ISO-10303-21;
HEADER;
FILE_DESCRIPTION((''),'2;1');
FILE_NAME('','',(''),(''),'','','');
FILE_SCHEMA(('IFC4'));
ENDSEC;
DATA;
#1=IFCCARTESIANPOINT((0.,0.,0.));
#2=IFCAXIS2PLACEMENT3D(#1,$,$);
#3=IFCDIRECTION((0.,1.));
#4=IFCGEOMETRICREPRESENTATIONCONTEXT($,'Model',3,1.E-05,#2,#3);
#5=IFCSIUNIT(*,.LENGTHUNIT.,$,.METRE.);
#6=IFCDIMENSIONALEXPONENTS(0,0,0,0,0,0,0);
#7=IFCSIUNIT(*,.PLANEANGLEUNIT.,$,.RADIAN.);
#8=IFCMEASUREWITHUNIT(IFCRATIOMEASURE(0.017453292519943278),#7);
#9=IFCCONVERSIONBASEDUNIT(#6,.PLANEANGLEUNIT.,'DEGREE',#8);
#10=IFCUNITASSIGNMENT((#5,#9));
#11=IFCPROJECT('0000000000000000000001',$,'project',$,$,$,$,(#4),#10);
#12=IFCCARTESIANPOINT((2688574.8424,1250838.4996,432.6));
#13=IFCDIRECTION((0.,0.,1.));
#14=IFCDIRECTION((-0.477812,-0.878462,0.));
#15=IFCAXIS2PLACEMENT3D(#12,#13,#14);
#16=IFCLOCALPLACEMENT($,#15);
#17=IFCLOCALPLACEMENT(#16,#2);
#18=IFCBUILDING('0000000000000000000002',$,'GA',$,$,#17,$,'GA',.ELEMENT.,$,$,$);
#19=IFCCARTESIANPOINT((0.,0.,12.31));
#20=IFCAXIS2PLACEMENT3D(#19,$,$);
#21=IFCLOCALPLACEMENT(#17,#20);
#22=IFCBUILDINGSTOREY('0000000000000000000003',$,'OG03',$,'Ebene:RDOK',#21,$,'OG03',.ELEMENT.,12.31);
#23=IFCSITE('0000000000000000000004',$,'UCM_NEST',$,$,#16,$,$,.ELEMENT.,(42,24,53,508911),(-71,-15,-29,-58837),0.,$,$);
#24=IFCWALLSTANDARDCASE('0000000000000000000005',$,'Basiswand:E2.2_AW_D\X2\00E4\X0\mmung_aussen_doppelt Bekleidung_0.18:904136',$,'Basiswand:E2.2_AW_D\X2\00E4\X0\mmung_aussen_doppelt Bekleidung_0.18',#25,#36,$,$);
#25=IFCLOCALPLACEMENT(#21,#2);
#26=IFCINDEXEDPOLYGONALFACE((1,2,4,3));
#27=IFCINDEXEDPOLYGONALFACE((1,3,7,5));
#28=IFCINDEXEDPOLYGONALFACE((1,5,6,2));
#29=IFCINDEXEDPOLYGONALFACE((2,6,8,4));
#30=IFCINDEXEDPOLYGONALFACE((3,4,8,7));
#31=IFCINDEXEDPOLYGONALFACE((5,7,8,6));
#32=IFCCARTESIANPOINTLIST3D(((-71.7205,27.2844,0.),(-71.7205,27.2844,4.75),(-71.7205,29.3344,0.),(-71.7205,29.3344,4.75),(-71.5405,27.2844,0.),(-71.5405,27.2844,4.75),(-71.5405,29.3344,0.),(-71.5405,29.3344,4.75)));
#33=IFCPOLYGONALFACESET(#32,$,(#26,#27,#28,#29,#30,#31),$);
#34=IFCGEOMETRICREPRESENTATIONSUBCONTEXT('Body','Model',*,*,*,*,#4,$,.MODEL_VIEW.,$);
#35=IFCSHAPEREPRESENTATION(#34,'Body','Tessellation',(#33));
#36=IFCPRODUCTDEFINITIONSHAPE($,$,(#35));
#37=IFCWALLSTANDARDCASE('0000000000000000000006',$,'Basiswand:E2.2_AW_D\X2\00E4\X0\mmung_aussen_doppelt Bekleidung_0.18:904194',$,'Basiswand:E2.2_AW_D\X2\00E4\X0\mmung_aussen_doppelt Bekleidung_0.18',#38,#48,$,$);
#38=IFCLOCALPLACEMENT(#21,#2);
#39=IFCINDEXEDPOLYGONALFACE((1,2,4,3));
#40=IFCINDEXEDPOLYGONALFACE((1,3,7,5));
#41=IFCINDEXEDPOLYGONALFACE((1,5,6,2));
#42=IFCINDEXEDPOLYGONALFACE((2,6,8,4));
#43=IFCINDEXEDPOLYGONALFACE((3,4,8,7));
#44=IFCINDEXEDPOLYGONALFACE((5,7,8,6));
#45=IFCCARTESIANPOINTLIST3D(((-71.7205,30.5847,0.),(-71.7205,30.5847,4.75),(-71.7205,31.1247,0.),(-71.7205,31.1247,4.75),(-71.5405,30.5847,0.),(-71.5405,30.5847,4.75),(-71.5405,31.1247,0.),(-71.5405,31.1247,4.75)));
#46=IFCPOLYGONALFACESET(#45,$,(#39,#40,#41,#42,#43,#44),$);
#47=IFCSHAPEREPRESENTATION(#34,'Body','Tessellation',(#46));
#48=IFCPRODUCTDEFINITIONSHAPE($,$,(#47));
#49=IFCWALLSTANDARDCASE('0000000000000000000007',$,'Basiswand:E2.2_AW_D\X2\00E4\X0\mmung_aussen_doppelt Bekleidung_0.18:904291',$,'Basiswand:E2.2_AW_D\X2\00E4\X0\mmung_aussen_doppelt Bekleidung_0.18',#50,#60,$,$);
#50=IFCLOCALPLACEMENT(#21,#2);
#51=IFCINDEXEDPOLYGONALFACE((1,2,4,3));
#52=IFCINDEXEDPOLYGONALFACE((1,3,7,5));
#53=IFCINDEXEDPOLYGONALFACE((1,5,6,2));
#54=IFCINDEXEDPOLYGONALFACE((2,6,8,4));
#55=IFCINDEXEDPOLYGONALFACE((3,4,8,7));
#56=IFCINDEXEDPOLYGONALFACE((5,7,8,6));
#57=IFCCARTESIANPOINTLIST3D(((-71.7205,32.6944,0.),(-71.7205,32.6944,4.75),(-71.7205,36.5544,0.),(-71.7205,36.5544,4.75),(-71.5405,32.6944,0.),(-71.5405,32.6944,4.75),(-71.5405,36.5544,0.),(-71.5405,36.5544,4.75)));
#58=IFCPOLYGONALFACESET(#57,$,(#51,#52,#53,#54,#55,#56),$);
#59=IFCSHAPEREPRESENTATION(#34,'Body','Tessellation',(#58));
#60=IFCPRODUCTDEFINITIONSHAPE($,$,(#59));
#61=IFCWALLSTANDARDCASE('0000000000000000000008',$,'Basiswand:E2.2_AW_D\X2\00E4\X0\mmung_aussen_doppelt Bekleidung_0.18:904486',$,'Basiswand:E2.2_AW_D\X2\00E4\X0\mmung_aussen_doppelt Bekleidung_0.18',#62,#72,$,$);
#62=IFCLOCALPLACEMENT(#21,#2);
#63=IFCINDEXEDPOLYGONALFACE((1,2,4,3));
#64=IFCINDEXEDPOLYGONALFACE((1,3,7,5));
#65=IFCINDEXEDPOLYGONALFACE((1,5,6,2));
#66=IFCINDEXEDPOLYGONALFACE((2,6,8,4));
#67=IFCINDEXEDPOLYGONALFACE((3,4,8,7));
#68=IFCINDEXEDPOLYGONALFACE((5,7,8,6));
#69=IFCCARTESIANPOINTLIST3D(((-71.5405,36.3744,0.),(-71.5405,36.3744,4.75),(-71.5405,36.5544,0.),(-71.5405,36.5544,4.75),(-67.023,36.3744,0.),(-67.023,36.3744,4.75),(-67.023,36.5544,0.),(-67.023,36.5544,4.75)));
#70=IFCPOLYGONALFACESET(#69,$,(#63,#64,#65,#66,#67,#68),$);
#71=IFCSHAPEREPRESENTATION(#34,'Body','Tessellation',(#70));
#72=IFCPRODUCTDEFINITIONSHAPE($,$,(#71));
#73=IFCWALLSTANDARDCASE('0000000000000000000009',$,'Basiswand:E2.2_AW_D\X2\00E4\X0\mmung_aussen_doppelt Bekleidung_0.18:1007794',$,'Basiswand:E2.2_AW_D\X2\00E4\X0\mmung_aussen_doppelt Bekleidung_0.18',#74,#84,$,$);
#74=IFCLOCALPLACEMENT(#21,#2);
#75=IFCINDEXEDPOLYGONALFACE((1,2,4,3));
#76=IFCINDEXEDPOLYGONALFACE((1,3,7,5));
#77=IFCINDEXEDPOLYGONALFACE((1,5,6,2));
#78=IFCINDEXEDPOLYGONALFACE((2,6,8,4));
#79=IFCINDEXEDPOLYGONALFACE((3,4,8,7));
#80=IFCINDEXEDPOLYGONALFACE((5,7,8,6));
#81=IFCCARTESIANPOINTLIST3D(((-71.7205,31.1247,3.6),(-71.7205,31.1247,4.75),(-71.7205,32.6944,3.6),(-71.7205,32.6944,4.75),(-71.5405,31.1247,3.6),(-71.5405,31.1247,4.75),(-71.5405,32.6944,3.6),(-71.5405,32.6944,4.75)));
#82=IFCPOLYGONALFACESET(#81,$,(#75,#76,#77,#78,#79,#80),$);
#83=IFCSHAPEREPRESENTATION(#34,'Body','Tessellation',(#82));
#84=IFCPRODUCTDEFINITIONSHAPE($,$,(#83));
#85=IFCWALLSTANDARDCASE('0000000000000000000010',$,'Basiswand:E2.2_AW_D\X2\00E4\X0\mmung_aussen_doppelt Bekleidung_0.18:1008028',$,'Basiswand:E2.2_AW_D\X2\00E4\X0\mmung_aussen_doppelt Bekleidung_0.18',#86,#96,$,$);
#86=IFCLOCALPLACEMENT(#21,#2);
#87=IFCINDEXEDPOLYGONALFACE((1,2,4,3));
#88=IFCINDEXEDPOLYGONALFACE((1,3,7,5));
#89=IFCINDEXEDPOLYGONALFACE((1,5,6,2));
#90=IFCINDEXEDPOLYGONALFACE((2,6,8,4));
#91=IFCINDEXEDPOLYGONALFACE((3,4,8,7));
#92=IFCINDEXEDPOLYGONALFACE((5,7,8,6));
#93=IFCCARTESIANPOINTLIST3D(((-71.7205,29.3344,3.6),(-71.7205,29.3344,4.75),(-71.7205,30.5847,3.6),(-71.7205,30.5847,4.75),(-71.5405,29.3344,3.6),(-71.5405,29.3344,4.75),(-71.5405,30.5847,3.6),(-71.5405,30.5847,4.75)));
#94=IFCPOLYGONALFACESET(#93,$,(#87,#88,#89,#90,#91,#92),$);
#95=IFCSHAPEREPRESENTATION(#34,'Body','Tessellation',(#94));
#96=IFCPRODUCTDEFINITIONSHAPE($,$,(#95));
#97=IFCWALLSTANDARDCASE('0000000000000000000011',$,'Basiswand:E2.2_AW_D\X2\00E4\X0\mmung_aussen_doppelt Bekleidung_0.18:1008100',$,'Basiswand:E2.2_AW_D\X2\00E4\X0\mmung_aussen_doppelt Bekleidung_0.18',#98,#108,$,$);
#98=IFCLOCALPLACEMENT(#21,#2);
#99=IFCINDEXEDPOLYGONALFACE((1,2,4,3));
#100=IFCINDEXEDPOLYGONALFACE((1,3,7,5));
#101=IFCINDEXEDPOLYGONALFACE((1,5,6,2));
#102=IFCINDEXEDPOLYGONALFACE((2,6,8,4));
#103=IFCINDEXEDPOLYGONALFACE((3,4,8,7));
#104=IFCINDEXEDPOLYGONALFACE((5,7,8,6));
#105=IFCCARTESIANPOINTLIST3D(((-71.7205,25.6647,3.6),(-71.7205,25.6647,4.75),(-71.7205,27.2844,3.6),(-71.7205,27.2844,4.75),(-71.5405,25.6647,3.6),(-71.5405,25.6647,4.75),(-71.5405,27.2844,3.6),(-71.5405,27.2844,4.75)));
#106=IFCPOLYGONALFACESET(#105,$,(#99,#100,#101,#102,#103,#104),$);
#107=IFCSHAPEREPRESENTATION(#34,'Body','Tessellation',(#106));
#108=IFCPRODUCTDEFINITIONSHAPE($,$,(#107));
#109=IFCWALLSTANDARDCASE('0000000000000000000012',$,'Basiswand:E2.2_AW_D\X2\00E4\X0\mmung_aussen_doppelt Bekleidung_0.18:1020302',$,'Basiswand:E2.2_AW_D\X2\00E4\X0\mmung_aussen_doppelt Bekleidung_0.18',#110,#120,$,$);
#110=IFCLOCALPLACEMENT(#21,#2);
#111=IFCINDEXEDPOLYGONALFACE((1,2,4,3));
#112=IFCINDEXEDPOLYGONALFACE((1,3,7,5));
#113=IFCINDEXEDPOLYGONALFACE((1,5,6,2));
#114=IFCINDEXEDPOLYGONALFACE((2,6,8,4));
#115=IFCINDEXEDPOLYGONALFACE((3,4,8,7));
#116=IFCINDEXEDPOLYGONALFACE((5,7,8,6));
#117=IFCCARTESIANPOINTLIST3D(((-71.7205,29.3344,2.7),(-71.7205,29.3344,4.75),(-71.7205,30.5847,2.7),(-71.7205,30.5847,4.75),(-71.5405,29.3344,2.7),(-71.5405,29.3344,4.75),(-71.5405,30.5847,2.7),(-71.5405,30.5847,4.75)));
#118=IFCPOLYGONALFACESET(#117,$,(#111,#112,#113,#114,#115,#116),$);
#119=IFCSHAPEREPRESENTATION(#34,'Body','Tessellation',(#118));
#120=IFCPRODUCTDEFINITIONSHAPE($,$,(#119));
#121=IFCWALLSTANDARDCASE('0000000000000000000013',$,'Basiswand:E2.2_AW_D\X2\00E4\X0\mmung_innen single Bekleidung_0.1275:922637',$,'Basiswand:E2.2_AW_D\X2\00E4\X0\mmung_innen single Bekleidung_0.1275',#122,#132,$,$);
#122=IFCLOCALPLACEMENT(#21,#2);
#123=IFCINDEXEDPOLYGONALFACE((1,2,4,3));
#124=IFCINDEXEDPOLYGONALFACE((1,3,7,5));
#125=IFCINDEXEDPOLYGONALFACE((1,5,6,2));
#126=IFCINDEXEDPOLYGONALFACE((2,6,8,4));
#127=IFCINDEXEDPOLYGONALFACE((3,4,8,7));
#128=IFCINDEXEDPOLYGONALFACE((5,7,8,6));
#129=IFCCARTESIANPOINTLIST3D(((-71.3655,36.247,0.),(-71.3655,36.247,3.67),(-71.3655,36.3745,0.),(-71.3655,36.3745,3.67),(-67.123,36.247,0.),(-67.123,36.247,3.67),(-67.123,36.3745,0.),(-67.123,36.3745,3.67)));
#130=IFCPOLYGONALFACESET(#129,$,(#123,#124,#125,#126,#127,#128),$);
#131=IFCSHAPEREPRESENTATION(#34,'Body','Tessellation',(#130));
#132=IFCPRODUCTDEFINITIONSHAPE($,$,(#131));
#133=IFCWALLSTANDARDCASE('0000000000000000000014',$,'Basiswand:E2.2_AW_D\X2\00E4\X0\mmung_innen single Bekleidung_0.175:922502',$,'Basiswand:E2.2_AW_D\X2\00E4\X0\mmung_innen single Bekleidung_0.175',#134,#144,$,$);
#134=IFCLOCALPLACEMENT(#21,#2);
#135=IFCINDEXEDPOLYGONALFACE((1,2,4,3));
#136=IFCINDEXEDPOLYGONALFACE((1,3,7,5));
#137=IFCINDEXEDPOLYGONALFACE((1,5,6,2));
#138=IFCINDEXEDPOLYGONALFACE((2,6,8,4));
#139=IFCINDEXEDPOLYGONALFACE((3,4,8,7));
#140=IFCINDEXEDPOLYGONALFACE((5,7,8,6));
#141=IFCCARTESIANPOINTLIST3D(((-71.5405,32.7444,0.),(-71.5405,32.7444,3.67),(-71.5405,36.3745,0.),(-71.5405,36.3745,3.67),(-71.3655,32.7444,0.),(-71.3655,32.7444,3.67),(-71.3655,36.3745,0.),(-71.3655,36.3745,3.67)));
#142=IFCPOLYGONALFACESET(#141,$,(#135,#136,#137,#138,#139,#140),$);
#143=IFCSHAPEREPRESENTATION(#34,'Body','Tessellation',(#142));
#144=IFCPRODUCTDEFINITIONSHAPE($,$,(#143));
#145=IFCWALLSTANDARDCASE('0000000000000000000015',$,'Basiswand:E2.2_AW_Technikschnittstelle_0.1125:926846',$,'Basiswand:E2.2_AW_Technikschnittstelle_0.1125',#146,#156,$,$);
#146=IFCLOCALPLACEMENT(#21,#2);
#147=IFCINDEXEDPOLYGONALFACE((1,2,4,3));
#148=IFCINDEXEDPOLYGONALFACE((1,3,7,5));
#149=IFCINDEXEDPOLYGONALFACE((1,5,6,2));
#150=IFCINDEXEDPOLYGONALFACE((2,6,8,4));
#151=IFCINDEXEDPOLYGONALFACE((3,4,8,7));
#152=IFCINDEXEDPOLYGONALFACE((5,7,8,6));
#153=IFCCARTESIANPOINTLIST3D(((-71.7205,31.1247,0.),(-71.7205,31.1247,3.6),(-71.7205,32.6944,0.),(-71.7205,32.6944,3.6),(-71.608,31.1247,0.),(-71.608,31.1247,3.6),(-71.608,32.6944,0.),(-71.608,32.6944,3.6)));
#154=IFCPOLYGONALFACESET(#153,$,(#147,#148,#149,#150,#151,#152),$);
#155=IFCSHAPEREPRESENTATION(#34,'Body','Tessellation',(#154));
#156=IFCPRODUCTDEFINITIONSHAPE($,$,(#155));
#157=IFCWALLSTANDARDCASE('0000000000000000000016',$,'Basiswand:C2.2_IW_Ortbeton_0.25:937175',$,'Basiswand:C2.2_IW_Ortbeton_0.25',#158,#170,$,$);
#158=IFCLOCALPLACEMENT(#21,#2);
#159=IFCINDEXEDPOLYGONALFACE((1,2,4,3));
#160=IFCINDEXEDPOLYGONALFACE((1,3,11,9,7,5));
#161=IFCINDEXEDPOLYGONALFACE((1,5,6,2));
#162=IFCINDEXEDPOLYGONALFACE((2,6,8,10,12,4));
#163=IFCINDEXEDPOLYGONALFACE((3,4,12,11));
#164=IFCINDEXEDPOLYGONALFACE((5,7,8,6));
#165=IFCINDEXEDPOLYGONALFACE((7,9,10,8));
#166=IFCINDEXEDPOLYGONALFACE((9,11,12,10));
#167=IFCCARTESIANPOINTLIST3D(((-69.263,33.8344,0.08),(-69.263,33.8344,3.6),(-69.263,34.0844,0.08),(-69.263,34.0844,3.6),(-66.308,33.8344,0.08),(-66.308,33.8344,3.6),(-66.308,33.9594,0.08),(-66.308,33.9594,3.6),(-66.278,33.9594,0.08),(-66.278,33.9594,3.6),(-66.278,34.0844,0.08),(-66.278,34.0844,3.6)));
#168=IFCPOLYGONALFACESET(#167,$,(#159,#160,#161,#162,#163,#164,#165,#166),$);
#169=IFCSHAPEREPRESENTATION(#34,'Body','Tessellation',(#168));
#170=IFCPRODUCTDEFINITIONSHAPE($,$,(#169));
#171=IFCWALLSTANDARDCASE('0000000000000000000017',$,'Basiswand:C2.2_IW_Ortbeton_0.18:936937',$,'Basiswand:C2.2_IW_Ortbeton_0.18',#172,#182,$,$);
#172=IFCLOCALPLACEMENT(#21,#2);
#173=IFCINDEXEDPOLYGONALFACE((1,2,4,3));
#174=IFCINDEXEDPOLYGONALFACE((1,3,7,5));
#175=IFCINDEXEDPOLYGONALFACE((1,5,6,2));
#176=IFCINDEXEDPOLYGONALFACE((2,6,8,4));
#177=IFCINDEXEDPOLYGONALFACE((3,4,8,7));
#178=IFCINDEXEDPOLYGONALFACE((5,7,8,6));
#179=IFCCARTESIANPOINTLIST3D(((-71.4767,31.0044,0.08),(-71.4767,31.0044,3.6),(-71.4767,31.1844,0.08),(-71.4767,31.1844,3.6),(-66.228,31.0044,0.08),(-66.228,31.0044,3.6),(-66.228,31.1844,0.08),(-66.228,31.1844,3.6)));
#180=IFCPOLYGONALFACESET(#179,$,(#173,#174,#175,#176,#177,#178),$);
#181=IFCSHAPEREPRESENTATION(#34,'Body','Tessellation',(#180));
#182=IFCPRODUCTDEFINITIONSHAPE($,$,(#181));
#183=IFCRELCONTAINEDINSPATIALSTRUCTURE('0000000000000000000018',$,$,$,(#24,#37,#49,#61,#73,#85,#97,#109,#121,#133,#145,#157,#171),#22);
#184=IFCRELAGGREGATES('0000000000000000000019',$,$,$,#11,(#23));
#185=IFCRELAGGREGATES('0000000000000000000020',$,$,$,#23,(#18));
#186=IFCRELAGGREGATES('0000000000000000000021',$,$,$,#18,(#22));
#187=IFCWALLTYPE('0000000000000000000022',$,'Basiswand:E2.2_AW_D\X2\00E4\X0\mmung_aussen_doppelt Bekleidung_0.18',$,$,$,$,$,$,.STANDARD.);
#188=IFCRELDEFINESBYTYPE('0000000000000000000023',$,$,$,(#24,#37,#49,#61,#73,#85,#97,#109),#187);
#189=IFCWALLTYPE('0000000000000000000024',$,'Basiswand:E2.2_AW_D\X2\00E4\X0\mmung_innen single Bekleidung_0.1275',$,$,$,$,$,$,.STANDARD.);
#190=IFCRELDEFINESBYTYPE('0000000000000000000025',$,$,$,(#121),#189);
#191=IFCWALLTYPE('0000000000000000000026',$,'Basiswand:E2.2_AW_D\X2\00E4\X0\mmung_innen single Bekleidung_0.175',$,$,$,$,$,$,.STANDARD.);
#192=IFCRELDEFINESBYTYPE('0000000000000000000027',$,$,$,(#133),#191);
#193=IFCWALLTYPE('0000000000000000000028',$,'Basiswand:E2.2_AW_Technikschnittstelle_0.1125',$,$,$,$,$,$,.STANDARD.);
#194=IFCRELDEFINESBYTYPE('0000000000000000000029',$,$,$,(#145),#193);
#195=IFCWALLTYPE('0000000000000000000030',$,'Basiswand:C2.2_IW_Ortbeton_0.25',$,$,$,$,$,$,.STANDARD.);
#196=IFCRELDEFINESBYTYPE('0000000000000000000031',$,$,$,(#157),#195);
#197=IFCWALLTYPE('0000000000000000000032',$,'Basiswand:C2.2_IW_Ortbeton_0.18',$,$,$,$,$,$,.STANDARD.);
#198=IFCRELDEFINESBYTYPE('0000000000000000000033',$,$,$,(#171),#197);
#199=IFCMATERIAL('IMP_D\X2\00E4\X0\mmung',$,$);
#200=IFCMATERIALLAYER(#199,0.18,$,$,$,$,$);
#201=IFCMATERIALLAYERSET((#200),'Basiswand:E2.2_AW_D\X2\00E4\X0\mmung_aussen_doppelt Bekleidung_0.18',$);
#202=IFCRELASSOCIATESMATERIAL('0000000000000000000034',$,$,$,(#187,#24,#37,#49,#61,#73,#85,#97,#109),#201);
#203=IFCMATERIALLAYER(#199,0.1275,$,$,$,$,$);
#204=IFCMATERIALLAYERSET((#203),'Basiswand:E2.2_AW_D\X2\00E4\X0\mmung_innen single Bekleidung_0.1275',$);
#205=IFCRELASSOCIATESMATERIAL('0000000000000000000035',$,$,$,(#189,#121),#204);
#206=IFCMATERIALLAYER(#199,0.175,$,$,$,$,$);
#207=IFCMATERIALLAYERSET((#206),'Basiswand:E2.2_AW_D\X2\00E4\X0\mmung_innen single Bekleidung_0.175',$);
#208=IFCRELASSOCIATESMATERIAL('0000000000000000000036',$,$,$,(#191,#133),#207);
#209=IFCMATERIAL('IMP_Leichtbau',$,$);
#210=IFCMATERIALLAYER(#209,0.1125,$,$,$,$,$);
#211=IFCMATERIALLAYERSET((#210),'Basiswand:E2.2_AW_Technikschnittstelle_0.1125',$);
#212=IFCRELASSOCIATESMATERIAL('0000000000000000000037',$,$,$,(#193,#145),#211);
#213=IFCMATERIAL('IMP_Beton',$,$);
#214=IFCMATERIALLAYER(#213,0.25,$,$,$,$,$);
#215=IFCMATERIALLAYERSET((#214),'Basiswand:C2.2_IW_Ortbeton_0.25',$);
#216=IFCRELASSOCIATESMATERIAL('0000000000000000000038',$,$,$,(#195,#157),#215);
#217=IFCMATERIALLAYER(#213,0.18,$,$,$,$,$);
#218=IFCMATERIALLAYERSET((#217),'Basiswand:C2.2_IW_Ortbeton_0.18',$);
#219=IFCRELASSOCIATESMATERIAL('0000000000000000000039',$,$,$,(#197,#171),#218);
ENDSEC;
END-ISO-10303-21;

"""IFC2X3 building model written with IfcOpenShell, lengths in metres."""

from ifc_helpers import new_model, entity, si_unit, converted_unit, direction, frame, frame_2d, origin, place, context, subcontext, project, spatial, polyline, rectangle, outline, extrude, clip, bounded_halfspace, material, layer, layer_set, layer_usage, type_object, element, save


model = new_model("IFC2X3")

# Units and contexts
model_context = context("Model", 3, precision=1e-05, world=origin(), true_north=direction((0.0, 1.0)))
body_context = subcontext(model_context, "Body", "Model", "MODEL_VIEW")
ifc_project = project(units=[si_unit("LENGTHUNIT", "METRE"), converted_unit("PLANEANGLEUNIT", "DEGREE", entity("IfcRatioMeasure", 0.017453292519943278), si_unit("PLANEANGLEUNIT", "RADIAN"), dimensions=[0, 0, 0, 0, 0, 0, 0])], contexts=[model_context])

# Site, building, storey
site_placement = place(None, frame((2688574.8424, 1250838.4996, 432.6), z_axis=(0.0, 0.0, 1.0), x_axis=(-0.477812, -0.878462, 0.0)))
site = spatial("IfcSite", under=ifc_project, at=site_placement, Name="UCM_NEST", CompositionType="ELEMENT", RefLatitude=(42, 24, 53, 508911), RefLongitude=(-71, -15, -29, -58837), RefElevation=0.0)
building_placement = place(site_placement, origin())
building = spatial("IfcBuilding", under=site, at=building_placement, Name="GA", LongName="GA", CompositionType="ELEMENT")
storey_placement = place(building_placement, frame((0.0, 0.0, 12.31)))
storey = spatial("IfcBuildingStorey", under=building, at=storey_placement, Name="OG03", ObjectType="Ebene:RDOK", LongName="OG03", CompositionType="ELEMENT", Elevation=12.31)

# Walls
ifc_material_1 = material(Name="IMP_Dämmung")
ifc_layer_1 = layer(ifc_material_1, 0.18)
ifc_layer_set_1 = layer_set([ifc_layer_1], Name="Basiswand:E2.2_AW_Dämmung_aussen_doppelt Bekleidung_0.18")
ifc_layer_usage_1 = layer_usage(ifc_layer_set_1, "AXIS2", "NEGATIVE", 0.09)
wall_type_1 = type_object("IfcWallType", Name="Basiswand:E2.2_AW_Dämmung_aussen_doppelt Bekleidung_0.18", PredefinedType="STANDARD", material=ifc_layer_set_1)
wall_1_placement = place(storey_placement, frame((-71.6305, 27.2844, 0.0), z_axis=(0.0, 0.0, 1.0), x_axis=(0.0, 1.0, 0.0)))
element("IfcWallStandardCase", 1, at=wall_1_placement, inside=storey, type_object=wall_type_1, material=ifc_layer_usage_1, Name="Basiswand:E2.2_AW_Dämmung_aussen_doppelt Bekleidung_0.18:904136", ObjectType="Basiswand:E2.2_AW_Dämmung_aussen_doppelt Bekleidung_0.18", context=body_context, shape_type="SweptSolid", body=[
    extrude(rectangle(XDim=2.05, YDim=0.18, at=frame_2d((1.025, 0.0), x_axis=(-1.0, 0.0))), origin(), (0.0, 0.0, 1.0), 4.75),
])
wall_2_placement = place(storey_placement, frame((-71.6305, 30.5847, 0.0), z_axis=(0.0, 0.0, 1.0), x_axis=(0.0, 1.0, 0.0)))
element("IfcWallStandardCase", 2, at=wall_2_placement, inside=storey, type_object=wall_type_1, material=ifc_layer_usage_1, Name="Basiswand:E2.2_AW_Dämmung_aussen_doppelt Bekleidung_0.18:904194", ObjectType="Basiswand:E2.2_AW_Dämmung_aussen_doppelt Bekleidung_0.18", context=body_context, shape_type="SweptSolid", body=[
    extrude(rectangle(XDim=0.54, YDim=0.18, at=frame_2d((0.27, 0.0), x_axis=(-1.0, 0.0))), origin(), (0.0, 0.0, 1.0), 4.75),
])
wall_3_placement = place(storey_placement, frame((-71.6305, 32.6944, 0.0), z_axis=(0.0, 0.0, 1.0), x_axis=(0.0, 1.0, 0.0)))
element("IfcWallStandardCase", 3, at=wall_3_placement, inside=storey, type_object=wall_type_1, material=ifc_layer_usage_1, Name="Basiswand:E2.2_AW_Dämmung_aussen_doppelt Bekleidung_0.18:904291", ObjectType="Basiswand:E2.2_AW_Dämmung_aussen_doppelt Bekleidung_0.18", context=body_context, shape_type="SweptSolid", body=[
    extrude(rectangle(XDim=3.86, YDim=0.18, at=frame_2d((1.93, 0.0), x_axis=(-1.0, 0.0))), origin(), (0.0, 0.0, 1.0), 4.75),
])
wall_4_placement = place(storey_placement, frame((-71.5405, 36.4644, 0.0)))
element("IfcWallStandardCase", 4, at=wall_4_placement, inside=storey, type_object=wall_type_1, material=ifc_layer_usage_1, Name="Basiswand:E2.2_AW_Dämmung_aussen_doppelt Bekleidung_0.18:904486", ObjectType="Basiswand:E2.2_AW_Dämmung_aussen_doppelt Bekleidung_0.18", context=body_context, shape_type="SweptSolid", body=[
    extrude(rectangle(XDim=4.5175, YDim=0.18, at=frame_2d((2.2587, 0.0), x_axis=(-1.0, 0.0))), origin(), (0.0, 0.0, 1.0), 4.75),
])
wall_5_placement = place(storey_placement, frame((-71.6305, 32.6944, 3.6), z_axis=(0.0, 0.0, 1.0), x_axis=(0.0, -1.0, 0.0)))
element("IfcWallStandardCase", 5, at=wall_5_placement, inside=storey, type_object=wall_type_1, material=ifc_layer_usage_1, Name="Basiswand:E2.2_AW_Dämmung_aussen_doppelt Bekleidung_0.18:1007794", ObjectType="Basiswand:E2.2_AW_Dämmung_aussen_doppelt Bekleidung_0.18", context=body_context, shape_type="SweptSolid", body=[
    extrude(rectangle(XDim=1.5698, YDim=0.18, at=frame_2d((0.7849, 0.0), x_axis=(-1.0, 0.0))), origin(), (0.0, 0.0, 1.0), 1.15),
])
wall_6_placement = place(storey_placement, frame((-71.6305, 30.5847, 3.6), z_axis=(0.0, 0.0, 1.0), x_axis=(0.0, -1.0, 0.0)))
element("IfcWallStandardCase", 6, at=wall_6_placement, inside=storey, type_object=wall_type_1, material=ifc_layer_usage_1, Name="Basiswand:E2.2_AW_Dämmung_aussen_doppelt Bekleidung_0.18:1008028", ObjectType="Basiswand:E2.2_AW_Dämmung_aussen_doppelt Bekleidung_0.18", context=body_context, shape_type="SweptSolid", body=[
    extrude(rectangle(XDim=1.2502, YDim=0.18, at=frame_2d((0.6251, 0.0), x_axis=(-1.0, 0.0))), origin(), (0.0, 0.0, 1.0), 1.15),
])
wall_7_placement = place(storey_placement, frame((-71.6305, 27.2844, 3.6), z_axis=(0.0, 0.0, 1.0), x_axis=(0.0, -1.0, 0.0)))
element("IfcWallStandardCase", 7, at=wall_7_placement, inside=storey, type_object=wall_type_1, material=ifc_layer_usage_1, Name="Basiswand:E2.2_AW_Dämmung_aussen_doppelt Bekleidung_0.18:1008100", ObjectType="Basiswand:E2.2_AW_Dämmung_aussen_doppelt Bekleidung_0.18", context=body_context, shape_type="SweptSolid", body=[
    extrude(rectangle(XDim=1.6197, YDim=0.18, at=frame_2d((0.8099, 0.0), x_axis=(-1.0, 0.0))), origin(), (0.0, 0.0, 1.0), 1.15),
])
wall_8_placement = place(storey_placement, frame((-71.6305, 29.3344, 2.7), z_axis=(0.0, 0.0, 1.0), x_axis=(0.0, 1.0, 0.0)))
element("IfcWallStandardCase", 8, at=wall_8_placement, inside=storey, type_object=wall_type_1, material=ifc_layer_usage_1, Name="Basiswand:E2.2_AW_Dämmung_aussen_doppelt Bekleidung_0.18:1020302", ObjectType="Basiswand:E2.2_AW_Dämmung_aussen_doppelt Bekleidung_0.18", context=body_context, shape_type="SweptSolid", body=[
    extrude(rectangle(XDim=1.2502, YDim=0.18, at=frame_2d((0.6251, 0.0), x_axis=(-1.0, 0.0))), origin(), (0.0, 0.0, 1.0), 2.05),
])

# Shared definitions
ifc_material_2 = material(Name="IMP_Beton")

# Walls
ifc_layer_2 = layer(ifc_material_1, 0.1275)
ifc_layer_set_2 = layer_set([ifc_layer_2], Name="Basiswand:E2.2_AW_Dämmung_innen single Bekleidung_0.1275")
ifc_layer_usage_2 = layer_usage(ifc_layer_set_2, "AXIS2", "NEGATIVE", 0.0638)
wall_type_2 = type_object("IfcWallType", Name="Basiswand:E2.2_AW_Dämmung_innen single Bekleidung_0.1275", PredefinedType="STANDARD", material=ifc_layer_set_2)
wall_9_placement = place(storey_placement, frame((-71.3655, 36.3107, 0.0)))
element("IfcWallStandardCase", 9, at=wall_9_placement, inside=storey, type_object=wall_type_2, material=ifc_layer_usage_2, Name="Basiswand:E2.2_AW_Dämmung_innen single Bekleidung_0.1275:922637", ObjectType="Basiswand:E2.2_AW_Dämmung_innen single Bekleidung_0.1275", context=body_context, shape_type="SweptSolid", body=[
    extrude(rectangle(XDim=4.2425, YDim=0.1275, at=frame_2d((2.1212, 0.0), x_axis=(-1.0, 0.0))), origin(), (0.0, 0.0, 1.0), 3.67),
])
ifc_layer_3 = layer(ifc_material_1, 0.175)
ifc_layer_set_3 = layer_set([ifc_layer_3], Name="Basiswand:E2.2_AW_Dämmung_innen single Bekleidung_0.175")
ifc_layer_usage_3 = layer_usage(ifc_layer_set_3, "AXIS2", "NEGATIVE", 0.0875)
wall_type_3 = type_object("IfcWallType", Name="Basiswand:E2.2_AW_Dämmung_innen single Bekleidung_0.175", PredefinedType="STANDARD", material=ifc_layer_set_3)
wall_10_placement = place(storey_placement, frame((-71.453, 32.7444, 0.0), z_axis=(0.0, 0.0, 1.0), x_axis=(0.0, 1.0, 0.0)))
element("IfcWallStandardCase", 10, at=wall_10_placement, inside=storey, type_object=wall_type_3, material=ifc_layer_usage_3, Name="Basiswand:E2.2_AW_Dämmung_innen single Bekleidung_0.175:922502", ObjectType="Basiswand:E2.2_AW_Dämmung_innen single Bekleidung_0.175", context=body_context, shape_type="SweptSolid", body=[
    extrude(rectangle(XDim=3.63, YDim=0.175, at=frame_2d((1.815, 0.0), x_axis=(-1.0, 0.0))), origin(), (0.0, 0.0, 1.0), 3.67),
])
ifc_material_3 = material(Name="IMP_Leichtbau")
ifc_layer_4 = layer(ifc_material_3, 0.1125)
ifc_layer_set_4 = layer_set([ifc_layer_4], Name="Basiswand:E2.2_AW_Technikschnittstelle_0.1125")
ifc_layer_usage_4 = layer_usage(ifc_layer_set_4, "AXIS2", "NEGATIVE", 0.0562)
wall_type_4 = type_object("IfcWallType", Name="Basiswand:E2.2_AW_Technikschnittstelle_0.1125", PredefinedType="STANDARD", material=ifc_layer_set_4)
wall_11_placement = place(storey_placement, frame((-71.6642, 31.1247, 0.0), z_axis=(0.0, 0.0, 1.0), x_axis=(0.0, 1.0, 0.0)))
element("IfcWallStandardCase", 11, at=wall_11_placement, inside=storey, type_object=wall_type_4, material=ifc_layer_usage_4, Name="Basiswand:E2.2_AW_Technikschnittstelle_0.1125:926846", ObjectType="Basiswand:E2.2_AW_Technikschnittstelle_0.1125", context=body_context, shape_type="SweptSolid", body=[
    extrude(rectangle(XDim=1.5698, YDim=0.1125, at=frame_2d((0.7849, 0.0), x_axis=(-1.0, 0.0))), origin(), (0.0, 0.0, 1.0), 3.6),
])
ifc_layer_5 = layer(ifc_material_2, 0.25)
ifc_layer_set_5 = layer_set([ifc_layer_5], Name="Basiswand:C2.2_IW_Ortbeton_0.25")
ifc_layer_usage_5 = layer_usage(ifc_layer_set_5, "AXIS2", "NEGATIVE", 0.125)
wall_type_5 = type_object("IfcWallType", Name="Basiswand:C2.2_IW_Ortbeton_0.25", PredefinedType="STANDARD", material=ifc_layer_set_5)
wall_12_placement = place(storey_placement, frame((-69.263, 33.9594, 0.08)))
element("IfcWallStandardCase", 12, at=wall_12_placement, inside=storey, type_object=wall_type_5, material=ifc_layer_usage_5, Name="Basiswand:C2.2_IW_Ortbeton_0.25:937175", ObjectType="Basiswand:C2.2_IW_Ortbeton_0.25", context=body_context, shape_type="Clipping", body=[
    clip(extrude(outline(polyline([(0.0, -0.125), (2.02, -0.125), (2.2, -0.125), (2.955, -0.125), (2.955, 0.0), (2.985, 0.0), (2.985, 0.125), (0.0, 0.125), (0.0, -0.125)])), origin(), (0.0, 0.0, 1.0), 3.52), bounded_halfspace(frame((2.955, -0.125, 0.0), z_axis=(0.0, 0.0, 1.0), x_axis=(-1.0, 0.0, 0.0)), True, frame((2.955, -0.125, 0.0), z_axis=(0.0, 0.0, 1.0), x_axis=(-1.0, 0.0, 0.0)), polyline([(0.0, 0.0), (0.0, -0.125), (-0.03, -0.125), (-0.03, -0.25), (2.955, -0.25), (2.955, 0.0), (0.935, 0.0), (0.755, 0.0), (0.0, 0.0)]))),
])
ifc_layer_6 = layer(ifc_material_2, 0.18)
ifc_layer_set_6 = layer_set([ifc_layer_6], Name="Basiswand:C2.2_IW_Ortbeton_0.18")
ifc_layer_usage_6 = layer_usage(ifc_layer_set_6, "AXIS2", "NEGATIVE", 0.09)
wall_type_6 = type_object("IfcWallType", Name="Basiswand:C2.2_IW_Ortbeton_0.18", PredefinedType="STANDARD", material=ifc_layer_set_6)
wall_13_placement = place(storey_placement, frame((-66.228, 31.0944, 0.08), z_axis=(0.0, 0.0, 1.0), x_axis=(-1.0, 0.0, 0.0)))
element("IfcWallStandardCase", 13, at=wall_13_placement, inside=storey, type_object=wall_type_6, material=ifc_layer_usage_6, Name="Basiswand:C2.2_IW_Ortbeton_0.18:936937", ObjectType="Basiswand:C2.2_IW_Ortbeton_0.18", context=body_context, shape_type="Clipping", body=[
    clip(extrude(rectangle(XDim=5.2488, YDim=0.18, at=frame_2d((2.6244, 0.0), x_axis=(-1.0, 0.0))), origin(), (0.0, 0.0, 1.0), 3.52), bounded_halfspace(frame((5.2488, -0.09, 0.0)), True, frame((5.2488, -0.09, 0.0)), polyline([(0.0, 0.0), (0.0, 0.18), (-5.2488, 0.18), (-5.2488, 0.0), (-4.4137, 0.0), (-4.2337, 0.0), (-2.2137, 0.0), (-2.0337, 0.0), (0.0, 0.0)]))),
])

save(model, "model.ifc")
